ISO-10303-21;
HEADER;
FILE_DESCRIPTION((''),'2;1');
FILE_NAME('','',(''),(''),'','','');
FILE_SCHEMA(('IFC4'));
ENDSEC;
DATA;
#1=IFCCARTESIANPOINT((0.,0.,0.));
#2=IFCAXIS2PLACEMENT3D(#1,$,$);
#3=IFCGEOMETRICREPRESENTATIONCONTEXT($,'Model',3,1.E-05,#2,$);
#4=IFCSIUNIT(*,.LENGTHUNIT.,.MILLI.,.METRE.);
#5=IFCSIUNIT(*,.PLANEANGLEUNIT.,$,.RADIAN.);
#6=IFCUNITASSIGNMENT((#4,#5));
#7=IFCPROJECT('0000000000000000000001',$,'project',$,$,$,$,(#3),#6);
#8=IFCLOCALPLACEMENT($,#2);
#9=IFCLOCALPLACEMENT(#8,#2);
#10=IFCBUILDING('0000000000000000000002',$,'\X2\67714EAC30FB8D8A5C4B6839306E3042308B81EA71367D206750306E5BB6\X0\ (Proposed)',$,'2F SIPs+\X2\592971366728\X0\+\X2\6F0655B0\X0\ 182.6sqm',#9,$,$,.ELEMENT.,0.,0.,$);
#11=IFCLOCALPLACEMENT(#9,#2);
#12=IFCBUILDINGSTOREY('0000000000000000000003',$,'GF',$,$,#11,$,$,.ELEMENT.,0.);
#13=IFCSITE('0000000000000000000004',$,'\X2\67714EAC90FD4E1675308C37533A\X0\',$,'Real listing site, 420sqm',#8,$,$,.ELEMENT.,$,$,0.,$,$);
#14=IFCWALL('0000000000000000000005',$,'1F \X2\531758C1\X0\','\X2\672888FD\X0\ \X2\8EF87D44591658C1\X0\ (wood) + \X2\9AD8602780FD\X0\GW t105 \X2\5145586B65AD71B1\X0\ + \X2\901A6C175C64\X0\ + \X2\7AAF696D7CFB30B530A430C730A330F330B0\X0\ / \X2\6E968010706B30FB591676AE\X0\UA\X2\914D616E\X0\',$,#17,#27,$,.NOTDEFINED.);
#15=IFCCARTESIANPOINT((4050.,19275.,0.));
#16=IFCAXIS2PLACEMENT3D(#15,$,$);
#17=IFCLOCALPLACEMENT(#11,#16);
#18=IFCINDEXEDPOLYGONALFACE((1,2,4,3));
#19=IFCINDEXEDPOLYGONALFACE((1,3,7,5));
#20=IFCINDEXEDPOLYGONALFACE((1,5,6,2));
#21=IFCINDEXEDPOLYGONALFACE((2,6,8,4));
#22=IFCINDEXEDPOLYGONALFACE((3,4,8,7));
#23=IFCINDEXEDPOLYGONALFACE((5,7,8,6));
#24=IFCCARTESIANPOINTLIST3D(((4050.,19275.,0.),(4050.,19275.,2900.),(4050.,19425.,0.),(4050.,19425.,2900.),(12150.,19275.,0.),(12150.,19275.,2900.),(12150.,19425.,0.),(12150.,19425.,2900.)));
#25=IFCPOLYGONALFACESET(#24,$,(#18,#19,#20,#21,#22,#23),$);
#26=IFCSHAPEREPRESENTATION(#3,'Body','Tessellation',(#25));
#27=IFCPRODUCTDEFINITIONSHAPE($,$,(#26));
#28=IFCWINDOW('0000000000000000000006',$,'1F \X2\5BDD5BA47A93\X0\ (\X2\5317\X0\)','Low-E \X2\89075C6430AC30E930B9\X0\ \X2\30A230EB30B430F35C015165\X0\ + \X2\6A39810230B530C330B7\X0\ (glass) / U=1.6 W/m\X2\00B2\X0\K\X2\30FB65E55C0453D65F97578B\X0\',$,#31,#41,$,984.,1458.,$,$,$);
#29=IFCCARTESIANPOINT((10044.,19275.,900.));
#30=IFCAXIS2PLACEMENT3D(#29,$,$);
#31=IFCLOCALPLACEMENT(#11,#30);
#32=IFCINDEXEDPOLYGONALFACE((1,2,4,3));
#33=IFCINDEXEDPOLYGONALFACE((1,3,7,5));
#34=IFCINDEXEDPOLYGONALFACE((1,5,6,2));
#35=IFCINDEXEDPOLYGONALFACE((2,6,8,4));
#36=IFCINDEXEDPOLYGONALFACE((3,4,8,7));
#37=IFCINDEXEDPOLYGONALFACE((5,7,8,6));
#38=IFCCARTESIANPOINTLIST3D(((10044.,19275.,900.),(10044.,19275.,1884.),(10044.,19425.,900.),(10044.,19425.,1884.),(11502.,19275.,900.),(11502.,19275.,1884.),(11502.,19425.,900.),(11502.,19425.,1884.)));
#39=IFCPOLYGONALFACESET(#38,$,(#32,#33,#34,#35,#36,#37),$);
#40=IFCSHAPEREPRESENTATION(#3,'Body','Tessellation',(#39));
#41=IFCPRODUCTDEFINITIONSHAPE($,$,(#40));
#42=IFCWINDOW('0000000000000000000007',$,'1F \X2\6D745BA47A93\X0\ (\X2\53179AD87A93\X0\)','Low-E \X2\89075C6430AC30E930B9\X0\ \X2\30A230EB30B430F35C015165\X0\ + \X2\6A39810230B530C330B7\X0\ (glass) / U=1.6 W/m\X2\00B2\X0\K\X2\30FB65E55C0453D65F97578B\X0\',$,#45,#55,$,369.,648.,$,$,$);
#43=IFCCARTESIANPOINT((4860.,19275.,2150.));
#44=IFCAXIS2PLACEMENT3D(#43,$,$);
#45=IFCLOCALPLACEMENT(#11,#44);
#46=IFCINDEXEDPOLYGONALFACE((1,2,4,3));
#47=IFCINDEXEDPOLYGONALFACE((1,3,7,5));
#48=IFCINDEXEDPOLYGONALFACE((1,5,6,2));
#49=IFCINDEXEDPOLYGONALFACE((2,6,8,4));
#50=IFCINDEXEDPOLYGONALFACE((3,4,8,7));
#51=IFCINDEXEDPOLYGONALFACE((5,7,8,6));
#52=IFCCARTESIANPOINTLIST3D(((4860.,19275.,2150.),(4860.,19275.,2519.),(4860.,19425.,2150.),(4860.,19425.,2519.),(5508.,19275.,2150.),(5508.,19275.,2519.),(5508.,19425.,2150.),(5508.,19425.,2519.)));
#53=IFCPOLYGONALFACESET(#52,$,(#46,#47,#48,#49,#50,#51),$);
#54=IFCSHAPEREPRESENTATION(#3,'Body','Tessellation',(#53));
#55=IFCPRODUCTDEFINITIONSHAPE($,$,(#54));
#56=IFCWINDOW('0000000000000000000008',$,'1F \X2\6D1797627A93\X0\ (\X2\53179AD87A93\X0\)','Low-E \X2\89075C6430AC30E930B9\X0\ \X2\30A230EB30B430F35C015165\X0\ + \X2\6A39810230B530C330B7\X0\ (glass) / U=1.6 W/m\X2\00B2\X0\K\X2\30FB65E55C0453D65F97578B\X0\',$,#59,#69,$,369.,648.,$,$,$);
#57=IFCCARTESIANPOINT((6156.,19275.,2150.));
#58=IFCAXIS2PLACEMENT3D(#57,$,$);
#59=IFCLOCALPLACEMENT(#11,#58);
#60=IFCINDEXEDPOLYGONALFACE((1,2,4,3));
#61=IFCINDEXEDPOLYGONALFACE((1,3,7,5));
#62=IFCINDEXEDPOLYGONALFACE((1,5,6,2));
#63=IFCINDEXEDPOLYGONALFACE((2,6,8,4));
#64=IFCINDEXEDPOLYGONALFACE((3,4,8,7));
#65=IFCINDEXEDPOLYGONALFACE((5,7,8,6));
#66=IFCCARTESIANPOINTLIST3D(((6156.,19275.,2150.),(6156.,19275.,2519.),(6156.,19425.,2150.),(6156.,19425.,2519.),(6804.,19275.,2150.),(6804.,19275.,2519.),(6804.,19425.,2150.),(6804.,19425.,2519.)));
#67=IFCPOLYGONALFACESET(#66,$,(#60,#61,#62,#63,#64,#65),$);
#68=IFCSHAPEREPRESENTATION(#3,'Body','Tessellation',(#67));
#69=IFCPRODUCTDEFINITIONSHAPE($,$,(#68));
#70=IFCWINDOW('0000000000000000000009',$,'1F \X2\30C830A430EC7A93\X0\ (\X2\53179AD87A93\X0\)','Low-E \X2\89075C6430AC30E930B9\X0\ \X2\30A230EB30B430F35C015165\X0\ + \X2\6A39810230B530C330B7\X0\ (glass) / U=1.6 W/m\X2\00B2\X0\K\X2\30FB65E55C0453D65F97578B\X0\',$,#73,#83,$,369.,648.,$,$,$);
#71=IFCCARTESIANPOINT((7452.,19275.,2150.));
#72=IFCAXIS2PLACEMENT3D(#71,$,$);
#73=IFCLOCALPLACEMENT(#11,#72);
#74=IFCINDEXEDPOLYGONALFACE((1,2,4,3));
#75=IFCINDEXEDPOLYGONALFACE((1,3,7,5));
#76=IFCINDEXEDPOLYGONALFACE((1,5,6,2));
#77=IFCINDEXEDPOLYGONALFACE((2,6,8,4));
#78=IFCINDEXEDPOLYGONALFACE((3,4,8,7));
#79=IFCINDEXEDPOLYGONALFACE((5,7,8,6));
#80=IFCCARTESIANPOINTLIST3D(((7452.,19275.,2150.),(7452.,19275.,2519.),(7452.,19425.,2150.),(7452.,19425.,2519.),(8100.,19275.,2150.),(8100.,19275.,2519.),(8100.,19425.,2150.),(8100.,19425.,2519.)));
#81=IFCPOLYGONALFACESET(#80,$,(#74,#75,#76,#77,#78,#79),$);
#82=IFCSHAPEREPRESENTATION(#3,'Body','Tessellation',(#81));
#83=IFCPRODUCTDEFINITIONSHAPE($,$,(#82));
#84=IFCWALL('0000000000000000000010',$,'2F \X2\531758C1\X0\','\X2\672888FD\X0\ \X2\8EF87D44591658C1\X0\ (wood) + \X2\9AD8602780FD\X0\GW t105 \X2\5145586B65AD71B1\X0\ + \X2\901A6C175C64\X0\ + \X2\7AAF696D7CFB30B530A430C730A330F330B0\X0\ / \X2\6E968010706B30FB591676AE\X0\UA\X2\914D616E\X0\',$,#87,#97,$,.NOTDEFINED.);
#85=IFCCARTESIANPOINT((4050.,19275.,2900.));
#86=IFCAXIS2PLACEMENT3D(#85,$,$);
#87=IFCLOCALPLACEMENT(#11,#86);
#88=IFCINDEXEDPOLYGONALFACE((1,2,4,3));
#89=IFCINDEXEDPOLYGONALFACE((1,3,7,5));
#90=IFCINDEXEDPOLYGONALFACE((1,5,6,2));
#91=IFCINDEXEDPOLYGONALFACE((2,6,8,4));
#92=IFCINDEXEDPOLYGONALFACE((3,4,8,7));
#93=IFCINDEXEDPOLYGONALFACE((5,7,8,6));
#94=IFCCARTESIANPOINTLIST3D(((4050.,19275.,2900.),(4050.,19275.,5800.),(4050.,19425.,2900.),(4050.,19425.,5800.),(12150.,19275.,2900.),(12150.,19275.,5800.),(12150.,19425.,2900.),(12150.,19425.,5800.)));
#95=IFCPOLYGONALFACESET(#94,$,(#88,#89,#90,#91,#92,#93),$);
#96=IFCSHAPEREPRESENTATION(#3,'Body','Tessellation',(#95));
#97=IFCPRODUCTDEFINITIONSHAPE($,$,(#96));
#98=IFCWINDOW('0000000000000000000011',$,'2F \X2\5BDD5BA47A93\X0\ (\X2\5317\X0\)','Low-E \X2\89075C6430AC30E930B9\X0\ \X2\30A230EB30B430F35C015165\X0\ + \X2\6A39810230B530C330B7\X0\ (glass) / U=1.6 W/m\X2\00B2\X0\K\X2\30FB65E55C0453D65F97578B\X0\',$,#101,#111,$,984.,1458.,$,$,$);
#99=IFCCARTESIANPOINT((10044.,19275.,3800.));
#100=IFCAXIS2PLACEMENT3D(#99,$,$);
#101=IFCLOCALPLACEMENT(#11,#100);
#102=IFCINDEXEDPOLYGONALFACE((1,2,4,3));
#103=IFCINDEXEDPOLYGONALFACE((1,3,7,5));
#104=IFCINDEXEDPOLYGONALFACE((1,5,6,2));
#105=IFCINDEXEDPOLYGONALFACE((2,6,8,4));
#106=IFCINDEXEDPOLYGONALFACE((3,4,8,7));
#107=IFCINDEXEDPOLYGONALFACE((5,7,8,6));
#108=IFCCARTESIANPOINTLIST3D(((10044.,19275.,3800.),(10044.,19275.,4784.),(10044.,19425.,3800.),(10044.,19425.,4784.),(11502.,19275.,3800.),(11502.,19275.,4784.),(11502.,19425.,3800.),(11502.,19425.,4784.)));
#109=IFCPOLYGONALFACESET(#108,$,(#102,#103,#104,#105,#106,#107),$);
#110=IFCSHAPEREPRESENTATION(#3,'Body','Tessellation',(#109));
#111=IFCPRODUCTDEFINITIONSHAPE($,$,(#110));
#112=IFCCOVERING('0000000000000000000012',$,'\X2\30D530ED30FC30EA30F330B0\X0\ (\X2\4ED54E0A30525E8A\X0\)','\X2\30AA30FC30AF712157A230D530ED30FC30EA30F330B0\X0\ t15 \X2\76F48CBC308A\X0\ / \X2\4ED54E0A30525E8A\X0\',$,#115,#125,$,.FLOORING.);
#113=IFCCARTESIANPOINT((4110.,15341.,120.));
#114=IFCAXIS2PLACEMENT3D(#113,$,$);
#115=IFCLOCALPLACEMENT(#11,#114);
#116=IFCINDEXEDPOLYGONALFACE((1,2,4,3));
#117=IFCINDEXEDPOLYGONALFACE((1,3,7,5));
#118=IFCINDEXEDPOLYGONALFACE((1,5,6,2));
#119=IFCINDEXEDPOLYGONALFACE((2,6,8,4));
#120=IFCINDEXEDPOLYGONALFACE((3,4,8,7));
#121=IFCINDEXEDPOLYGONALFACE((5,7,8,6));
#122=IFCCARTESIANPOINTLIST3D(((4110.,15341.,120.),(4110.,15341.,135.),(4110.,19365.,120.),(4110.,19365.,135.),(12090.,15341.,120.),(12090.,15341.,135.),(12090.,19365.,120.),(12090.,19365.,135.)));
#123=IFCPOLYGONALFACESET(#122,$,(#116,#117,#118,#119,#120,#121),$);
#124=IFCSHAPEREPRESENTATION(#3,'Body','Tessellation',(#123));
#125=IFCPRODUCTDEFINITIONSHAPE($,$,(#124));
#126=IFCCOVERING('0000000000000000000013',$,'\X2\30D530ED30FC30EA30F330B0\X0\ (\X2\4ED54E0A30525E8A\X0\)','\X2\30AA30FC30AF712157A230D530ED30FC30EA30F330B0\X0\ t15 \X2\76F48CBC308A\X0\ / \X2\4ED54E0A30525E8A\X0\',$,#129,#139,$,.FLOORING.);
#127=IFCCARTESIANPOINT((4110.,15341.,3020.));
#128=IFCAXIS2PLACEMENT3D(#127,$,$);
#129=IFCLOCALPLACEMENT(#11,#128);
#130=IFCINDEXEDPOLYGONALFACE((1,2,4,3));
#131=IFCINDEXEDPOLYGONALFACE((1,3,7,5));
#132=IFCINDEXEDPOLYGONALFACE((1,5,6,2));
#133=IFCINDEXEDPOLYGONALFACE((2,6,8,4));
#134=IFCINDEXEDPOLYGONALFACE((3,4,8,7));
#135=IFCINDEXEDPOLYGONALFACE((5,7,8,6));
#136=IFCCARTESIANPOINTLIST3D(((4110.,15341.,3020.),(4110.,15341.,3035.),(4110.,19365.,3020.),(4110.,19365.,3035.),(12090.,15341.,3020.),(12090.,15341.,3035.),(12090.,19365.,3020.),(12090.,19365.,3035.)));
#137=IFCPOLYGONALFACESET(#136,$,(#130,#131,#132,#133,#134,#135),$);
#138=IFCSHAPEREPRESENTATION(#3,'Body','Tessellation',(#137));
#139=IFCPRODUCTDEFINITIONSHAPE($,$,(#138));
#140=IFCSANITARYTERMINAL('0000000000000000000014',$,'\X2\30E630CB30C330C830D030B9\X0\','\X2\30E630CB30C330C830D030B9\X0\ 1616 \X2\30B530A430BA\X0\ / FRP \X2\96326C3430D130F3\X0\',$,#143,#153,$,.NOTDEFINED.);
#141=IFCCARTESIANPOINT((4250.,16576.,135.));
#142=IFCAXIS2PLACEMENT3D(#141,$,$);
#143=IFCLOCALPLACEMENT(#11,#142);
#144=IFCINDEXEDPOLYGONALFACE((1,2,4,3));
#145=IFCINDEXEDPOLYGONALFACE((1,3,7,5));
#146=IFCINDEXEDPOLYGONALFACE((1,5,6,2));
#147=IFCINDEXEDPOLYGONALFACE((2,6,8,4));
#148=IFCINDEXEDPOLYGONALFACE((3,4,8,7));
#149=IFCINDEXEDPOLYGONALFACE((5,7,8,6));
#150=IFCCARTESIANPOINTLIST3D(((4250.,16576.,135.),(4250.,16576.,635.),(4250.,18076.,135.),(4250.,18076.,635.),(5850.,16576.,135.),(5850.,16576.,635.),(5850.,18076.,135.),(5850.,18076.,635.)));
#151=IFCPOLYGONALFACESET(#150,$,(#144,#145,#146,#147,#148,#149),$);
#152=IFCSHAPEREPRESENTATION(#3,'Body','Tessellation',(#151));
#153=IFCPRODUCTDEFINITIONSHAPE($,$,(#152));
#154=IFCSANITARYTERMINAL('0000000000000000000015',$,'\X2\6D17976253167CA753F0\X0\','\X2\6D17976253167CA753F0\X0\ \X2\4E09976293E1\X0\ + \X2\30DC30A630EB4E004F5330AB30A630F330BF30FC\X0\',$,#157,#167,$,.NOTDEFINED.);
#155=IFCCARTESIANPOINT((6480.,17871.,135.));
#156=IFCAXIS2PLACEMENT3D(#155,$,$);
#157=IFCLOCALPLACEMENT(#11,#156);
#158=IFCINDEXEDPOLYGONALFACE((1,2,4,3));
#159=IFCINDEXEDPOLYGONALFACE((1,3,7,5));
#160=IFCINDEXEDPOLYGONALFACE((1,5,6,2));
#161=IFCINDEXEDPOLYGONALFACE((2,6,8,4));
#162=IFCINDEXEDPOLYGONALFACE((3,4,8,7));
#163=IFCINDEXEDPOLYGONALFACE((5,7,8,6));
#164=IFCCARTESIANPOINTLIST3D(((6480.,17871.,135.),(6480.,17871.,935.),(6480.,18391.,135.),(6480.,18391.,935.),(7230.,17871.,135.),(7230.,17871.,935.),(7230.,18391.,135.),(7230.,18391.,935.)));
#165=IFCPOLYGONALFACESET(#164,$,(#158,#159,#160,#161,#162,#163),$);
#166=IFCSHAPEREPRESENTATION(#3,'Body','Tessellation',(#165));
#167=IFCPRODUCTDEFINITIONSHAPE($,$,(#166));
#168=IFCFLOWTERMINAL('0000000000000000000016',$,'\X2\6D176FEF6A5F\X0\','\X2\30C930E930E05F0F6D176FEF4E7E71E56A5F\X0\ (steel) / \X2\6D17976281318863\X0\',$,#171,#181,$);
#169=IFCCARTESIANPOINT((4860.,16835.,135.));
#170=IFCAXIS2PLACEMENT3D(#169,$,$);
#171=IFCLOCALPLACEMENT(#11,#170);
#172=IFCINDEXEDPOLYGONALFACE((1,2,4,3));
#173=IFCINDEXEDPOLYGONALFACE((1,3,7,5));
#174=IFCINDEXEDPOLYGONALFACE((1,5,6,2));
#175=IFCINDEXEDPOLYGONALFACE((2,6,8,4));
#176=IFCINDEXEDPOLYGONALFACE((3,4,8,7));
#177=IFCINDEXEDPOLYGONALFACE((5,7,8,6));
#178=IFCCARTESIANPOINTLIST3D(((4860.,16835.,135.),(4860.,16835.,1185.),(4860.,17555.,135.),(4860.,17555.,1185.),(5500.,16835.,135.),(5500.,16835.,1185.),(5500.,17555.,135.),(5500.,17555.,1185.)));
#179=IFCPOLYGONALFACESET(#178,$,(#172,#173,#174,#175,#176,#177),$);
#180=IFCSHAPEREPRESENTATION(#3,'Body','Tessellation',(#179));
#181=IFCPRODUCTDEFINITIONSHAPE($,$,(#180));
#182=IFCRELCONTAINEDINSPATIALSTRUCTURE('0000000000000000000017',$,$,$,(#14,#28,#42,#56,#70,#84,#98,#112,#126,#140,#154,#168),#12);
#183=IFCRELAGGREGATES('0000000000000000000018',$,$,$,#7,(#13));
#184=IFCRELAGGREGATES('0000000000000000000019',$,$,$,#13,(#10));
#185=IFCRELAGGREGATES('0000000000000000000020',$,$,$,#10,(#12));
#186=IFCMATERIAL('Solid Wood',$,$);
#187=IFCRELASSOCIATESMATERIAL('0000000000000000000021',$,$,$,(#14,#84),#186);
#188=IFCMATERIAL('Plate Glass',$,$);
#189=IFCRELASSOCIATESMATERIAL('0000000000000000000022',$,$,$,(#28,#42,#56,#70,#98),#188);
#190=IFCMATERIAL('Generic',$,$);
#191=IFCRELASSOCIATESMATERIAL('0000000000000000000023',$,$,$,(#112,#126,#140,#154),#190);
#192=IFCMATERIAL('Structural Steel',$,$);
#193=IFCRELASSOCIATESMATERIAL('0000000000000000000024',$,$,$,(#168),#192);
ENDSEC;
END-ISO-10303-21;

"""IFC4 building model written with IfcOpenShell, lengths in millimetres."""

from ifc_helpers import new_model, si_unit, frame, frame_2d, origin, place, context, project, spatial, rectangle, extrude, material, element, fill, save


model = new_model("IFC4")

# Units and contexts
model_context = context("Model", 3, precision=1e-05, world=origin())
ifc_project = project(units=[si_unit("LENGTHUNIT", "METRE", prefix="MILLI"), si_unit("PLANEANGLEUNIT", "RADIAN")], contexts=[model_context])

# Site, building, storey
site_placement = place(None, origin())
site = spatial("IfcSite", under=ifc_project, at=site_placement, Name="東京都世田谷区", ObjectType="Real listing site, 420sqm", CompositionType="ELEMENT", RefElevation=0.0)
building_placement = place(site_placement, origin())
building = spatial("IfcBuilding", under=site, at=building_placement, Name="東京・越屋根のある自然素材の家 (Proposed)", ObjectType="2F SIPs+天然木+漆喰 182.6sqm", CompositionType="ELEMENT", ElevationOfRefHeight=0.0, ElevationOfTerrain=0.0)
storey_placement = place(building_placement, origin())
storey = spatial("IfcBuildingStorey", under=building, at=storey_placement, Name="GF", CompositionType="ELEMENT", Elevation=0.0)

# Shared definitions
ifc_material_1 = material(Name="Solid Wood")

# Wall, openings, windows
wall_1_placement = place(storey_placement, frame((4050.0, 19275.0, 0.0)))
wall_1 = element("IfcWall", 1, at=wall_1_placement, inside=storey, material=ifc_material_1, Name="1F 北壁", Description="木製 軸組外壁 (wood) + 高性能GW t105 充填断熱 + 通気層 + 窯業系サイディング / 準耐火・外皮UA配慮", PredefinedType="NOTDEFINED", context=model_context, shape_type="SweptSolid", body=[
    extrude(rectangle(XDim=8100.0, YDim=150.0, at=frame_2d((4050.0, 75.0))), frame((4050.0, 19275.0, 0.0)), (0.0, 0.0, 1.0), 2900.0),
])
opening_1_placement = place(storey_placement, frame((10044.0, 19275.0, 900.0)))
opening_1 = element("IfcOpeningElement", 2, at=opening_1_placement, cuts=wall_1, PredefinedType="NOTDEFINED", context=model_context, shape_type="SweptSolid", body=[
    extrude(rectangle(XDim=1458.0, YDim=150.0, at=frame_2d((729.0, 75.0))), frame((10044.0, 19275.0, 900.0)), (0.0, 0.0, 1.0), 984.0),
])
opening_2_placement = place(storey_placement, frame((4860.0, 19275.0, 2150.0)))
opening_2 = element("IfcOpeningElement", 3, at=opening_2_placement, cuts=wall_1, PredefinedType="NOTDEFINED", context=model_context, shape_type="SweptSolid", body=[
    extrude(rectangle(XDim=648.0, YDim=150.0, at=frame_2d((324.0, 75.0))), frame((4860.0, 19275.0, 2150.0)), (0.0, 0.0, 1.0), 369.0),
])
opening_3_placement = place(storey_placement, frame((6156.0, 19275.0, 2150.0)))
opening_3 = element("IfcOpeningElement", 4, at=opening_3_placement, cuts=wall_1, PredefinedType="NOTDEFINED", context=model_context, shape_type="SweptSolid", body=[
    extrude(rectangle(XDim=648.0, YDim=150.0, at=frame_2d((324.0, 75.0))), frame((6156.0, 19275.0, 2150.0)), (0.0, 0.0, 1.0), 369.0),
])
opening_4_placement = place(storey_placement, frame((7452.0, 19275.0, 2150.0)))
opening_4 = element("IfcOpeningElement", 5, at=opening_4_placement, cuts=wall_1, PredefinedType="NOTDEFINED", context=model_context, shape_type="SweptSolid", body=[
    extrude(rectangle(XDim=648.0, YDim=150.0, at=frame_2d((324.0, 75.0))), frame((7452.0, 19275.0, 2150.0)), (0.0, 0.0, 1.0), 369.0),
])
ifc_material_2 = material(Name="Plate Glass")
window_1_placement = place(storey_placement, frame((10044.0, 19275.0, 900.0)))
window_1 = element("IfcWindow", 6, at=window_1_placement, inside=storey, material=ifc_material_2, Name="1F 寝室窓 (北)", Description="Low-E 複層ガラス アルゴン封入 + 樹脂サッシ (glass) / U=1.6 W/m²K・日射取得型", OverallHeight=984.0, OverallWidth=1458.0, context=model_context, shape_type="SweptSolid", body=[
    extrude(rectangle(XDim=1458.0, YDim=150.0, at=frame_2d((729.0, 75.0))), frame((10044.0, 19275.0, 900.0)), (0.0, 0.0, 1.0), 984.0),
])
fill(opening_1, window_1)
window_2_placement = place(storey_placement, frame((4860.0, 19275.0, 2150.0)))
window_2 = element("IfcWindow", 7, at=window_2_placement, inside=storey, material=ifc_material_2, Name="1F 浴室窓 (北高窓)", Description="Low-E 複層ガラス アルゴン封入 + 樹脂サッシ (glass) / U=1.6 W/m²K・日射取得型", OverallHeight=369.0, OverallWidth=648.0, context=model_context, shape_type="SweptSolid", body=[
    extrude(rectangle(XDim=648.0, YDim=150.0, at=frame_2d((324.0, 75.0))), frame((4860.0, 19275.0, 2150.0)), (0.0, 0.0, 1.0), 369.0),
])
fill(opening_2, window_2)
window_3_placement = place(storey_placement, frame((6156.0, 19275.0, 2150.0)))
window_3 = element("IfcWindow", 8, at=window_3_placement, inside=storey, material=ifc_material_2, Name="1F 洗面窓 (北高窓)", Description="Low-E 複層ガラス アルゴン封入 + 樹脂サッシ (glass) / U=1.6 W/m²K・日射取得型", OverallHeight=369.0, OverallWidth=648.0, context=model_context, shape_type="SweptSolid", body=[
    extrude(rectangle(XDim=648.0, YDim=150.0, at=frame_2d((324.0, 75.0))), frame((6156.0, 19275.0, 2150.0)), (0.0, 0.0, 1.0), 369.0),
])
fill(opening_3, window_3)
window_4_placement = place(storey_placement, frame((7452.0, 19275.0, 2150.0)))
window_4 = element("IfcWindow", 9, at=window_4_placement, inside=storey, material=ifc_material_2, Name="1F トイレ窓 (北高窓)", Description="Low-E 複層ガラス アルゴン封入 + 樹脂サッシ (glass) / U=1.6 W/m²K・日射取得型", OverallHeight=369.0, OverallWidth=648.0, context=model_context, shape_type="SweptSolid", body=[
    extrude(rectangle(XDim=648.0, YDim=150.0, at=frame_2d((324.0, 75.0))), frame((7452.0, 19275.0, 2150.0)), (0.0, 0.0, 1.0), 369.0),
])
fill(opening_4, window_4)

# Wall, opening, window
wall_2_placement = place(storey_placement, frame((4050.0, 19275.0, 2900.0)))
wall_2 = element("IfcWall", 10, at=wall_2_placement, inside=storey, material=ifc_material_1, Name="2F 北壁", Description="木製 軸組外壁 (wood) + 高性能GW t105 充填断熱 + 通気層 + 窯業系サイディング / 準耐火・外皮UA配慮", PredefinedType="NOTDEFINED", context=model_context, shape_type="SweptSolid", body=[
    extrude(rectangle(XDim=8100.0, YDim=150.0, at=frame_2d((4050.0, 75.0))), frame((4050.0, 19275.0, 2900.0)), (0.0, 0.0, 1.0), 2900.0),
])
opening_5_placement = place(storey_placement, frame((10044.0, 19275.0, 3800.0)))
opening_5 = element("IfcOpeningElement", 11, at=opening_5_placement, cuts=wall_2, PredefinedType="NOTDEFINED", context=model_context, shape_type="SweptSolid", body=[
    extrude(rectangle(XDim=1458.0, YDim=150.0, at=frame_2d((729.0, 75.0))), frame((10044.0, 19275.0, 3800.0)), (0.0, 0.0, 1.0), 984.0),
])
window_5_placement = place(storey_placement, frame((10044.0, 19275.0, 3800.0)))
window_5 = element("IfcWindow", 12, at=window_5_placement, inside=storey, material=ifc_material_2, Name="2F 寝室窓 (北)", Description="Low-E 複層ガラス アルゴン封入 + 樹脂サッシ (glass) / U=1.6 W/m²K・日射取得型", OverallHeight=984.0, OverallWidth=1458.0, context=model_context, shape_type="SweptSolid", body=[
    extrude(rectangle(XDim=1458.0, YDim=150.0, at=frame_2d((729.0, 75.0))), frame((10044.0, 19275.0, 3800.0)), (0.0, 0.0, 1.0), 984.0),
])
fill(opening_5, window_5)

# Coverings
ifc_material_3 = material(Name="Generic")
covering_1_placement = place(storey_placement, frame((4110.0, 15341.0, 120.0)))
element("IfcCovering", 13, at=covering_1_placement, inside=storey, material=ifc_material_3, Name="フローリング (仕上げ床)", Description="オーク無垢フローリング t15 直貼り / 仕上げ床", PredefinedType="FLOORING", context=model_context, shape_type="SweptSolid", body=[
    extrude(rectangle(XDim=7980.0, YDim=4024.0, at=frame_2d((3990.0, 2012.0))), frame((4110.0, 15341.0, 120.0)), (0.0, 0.0, 1.0), 15.0),
])
covering_2_placement = place(storey_placement, frame((4110.0, 15341.0, 3020.0)))
element("IfcCovering", 14, at=covering_2_placement, inside=storey, material=ifc_material_3, Name="フローリング (仕上げ床)", Description="オーク無垢フローリング t15 直貼り / 仕上げ床", PredefinedType="FLOORING", context=model_context, shape_type="SweptSolid", body=[
    extrude(rectangle(XDim=7980.0, YDim=4024.0, at=frame_2d((3990.0, 2012.0))), frame((4110.0, 15341.0, 3020.0)), (0.0, 0.0, 1.0), 15.0),
])

# Sanitary terminals
sanitary_terminal_1_placement = place(storey_placement, frame((4250.0, 16576.0, 135.0)))
element("IfcSanitaryTerminal", 15, at=sanitary_terminal_1_placement, inside=storey, material=ifc_material_3, Name="ユニットバス", Description="ユニットバス 1616 サイズ / FRP 防水パン", PredefinedType="NOTDEFINED", context=model_context, shape_type="SweptSolid", body=[
    extrude(rectangle(XDim=1600.0, YDim=1500.0, at=frame_2d((800.0, 750.0))), frame((4250.0, 16576.0, 135.0)), (0.0, 0.0, 1.0), 500.0),
])
sanitary_terminal_2_placement = place(storey_placement, frame((6480.0, 17871.0, 135.0)))
element("IfcSanitaryTerminal", 16, at=sanitary_terminal_2_placement, inside=storey, material=ifc_material_3, Name="洗面化粧台", Description="洗面化粧台 三面鏡 + ボウル一体カウンター", PredefinedType="NOTDEFINED", context=model_context, shape_type="SweptSolid", body=[
    extrude(rectangle(XDim=750.0, YDim=520.0, at=frame_2d((375.0, 260.0))), frame((6480.0, 17871.0, 135.0)), (0.0, 0.0, 1.0), 800.0),
])

# Flow terminal
ifc_material_4 = material(Name="Structural Steel")
flow_terminal_placement = place(storey_placement, frame((4860.0, 16835.0, 135.0)))
element("IfcFlowTerminal", 17, at=flow_terminal_placement, inside=storey, material=ifc_material_4, Name="洗濯機", Description="ドラム式洗濯乾燥機 (steel) / 洗面脱衣", context=model_context, shape_type="SweptSolid", body=[
    extrude(rectangle(XDim=640.0, YDim=720.0, at=frame_2d((320.0, 360.0))), frame((4860.0, 16835.0, 135.0)), (0.0, 0.0, 1.0), 1050.0),
])

save(model, "model.ifc")
